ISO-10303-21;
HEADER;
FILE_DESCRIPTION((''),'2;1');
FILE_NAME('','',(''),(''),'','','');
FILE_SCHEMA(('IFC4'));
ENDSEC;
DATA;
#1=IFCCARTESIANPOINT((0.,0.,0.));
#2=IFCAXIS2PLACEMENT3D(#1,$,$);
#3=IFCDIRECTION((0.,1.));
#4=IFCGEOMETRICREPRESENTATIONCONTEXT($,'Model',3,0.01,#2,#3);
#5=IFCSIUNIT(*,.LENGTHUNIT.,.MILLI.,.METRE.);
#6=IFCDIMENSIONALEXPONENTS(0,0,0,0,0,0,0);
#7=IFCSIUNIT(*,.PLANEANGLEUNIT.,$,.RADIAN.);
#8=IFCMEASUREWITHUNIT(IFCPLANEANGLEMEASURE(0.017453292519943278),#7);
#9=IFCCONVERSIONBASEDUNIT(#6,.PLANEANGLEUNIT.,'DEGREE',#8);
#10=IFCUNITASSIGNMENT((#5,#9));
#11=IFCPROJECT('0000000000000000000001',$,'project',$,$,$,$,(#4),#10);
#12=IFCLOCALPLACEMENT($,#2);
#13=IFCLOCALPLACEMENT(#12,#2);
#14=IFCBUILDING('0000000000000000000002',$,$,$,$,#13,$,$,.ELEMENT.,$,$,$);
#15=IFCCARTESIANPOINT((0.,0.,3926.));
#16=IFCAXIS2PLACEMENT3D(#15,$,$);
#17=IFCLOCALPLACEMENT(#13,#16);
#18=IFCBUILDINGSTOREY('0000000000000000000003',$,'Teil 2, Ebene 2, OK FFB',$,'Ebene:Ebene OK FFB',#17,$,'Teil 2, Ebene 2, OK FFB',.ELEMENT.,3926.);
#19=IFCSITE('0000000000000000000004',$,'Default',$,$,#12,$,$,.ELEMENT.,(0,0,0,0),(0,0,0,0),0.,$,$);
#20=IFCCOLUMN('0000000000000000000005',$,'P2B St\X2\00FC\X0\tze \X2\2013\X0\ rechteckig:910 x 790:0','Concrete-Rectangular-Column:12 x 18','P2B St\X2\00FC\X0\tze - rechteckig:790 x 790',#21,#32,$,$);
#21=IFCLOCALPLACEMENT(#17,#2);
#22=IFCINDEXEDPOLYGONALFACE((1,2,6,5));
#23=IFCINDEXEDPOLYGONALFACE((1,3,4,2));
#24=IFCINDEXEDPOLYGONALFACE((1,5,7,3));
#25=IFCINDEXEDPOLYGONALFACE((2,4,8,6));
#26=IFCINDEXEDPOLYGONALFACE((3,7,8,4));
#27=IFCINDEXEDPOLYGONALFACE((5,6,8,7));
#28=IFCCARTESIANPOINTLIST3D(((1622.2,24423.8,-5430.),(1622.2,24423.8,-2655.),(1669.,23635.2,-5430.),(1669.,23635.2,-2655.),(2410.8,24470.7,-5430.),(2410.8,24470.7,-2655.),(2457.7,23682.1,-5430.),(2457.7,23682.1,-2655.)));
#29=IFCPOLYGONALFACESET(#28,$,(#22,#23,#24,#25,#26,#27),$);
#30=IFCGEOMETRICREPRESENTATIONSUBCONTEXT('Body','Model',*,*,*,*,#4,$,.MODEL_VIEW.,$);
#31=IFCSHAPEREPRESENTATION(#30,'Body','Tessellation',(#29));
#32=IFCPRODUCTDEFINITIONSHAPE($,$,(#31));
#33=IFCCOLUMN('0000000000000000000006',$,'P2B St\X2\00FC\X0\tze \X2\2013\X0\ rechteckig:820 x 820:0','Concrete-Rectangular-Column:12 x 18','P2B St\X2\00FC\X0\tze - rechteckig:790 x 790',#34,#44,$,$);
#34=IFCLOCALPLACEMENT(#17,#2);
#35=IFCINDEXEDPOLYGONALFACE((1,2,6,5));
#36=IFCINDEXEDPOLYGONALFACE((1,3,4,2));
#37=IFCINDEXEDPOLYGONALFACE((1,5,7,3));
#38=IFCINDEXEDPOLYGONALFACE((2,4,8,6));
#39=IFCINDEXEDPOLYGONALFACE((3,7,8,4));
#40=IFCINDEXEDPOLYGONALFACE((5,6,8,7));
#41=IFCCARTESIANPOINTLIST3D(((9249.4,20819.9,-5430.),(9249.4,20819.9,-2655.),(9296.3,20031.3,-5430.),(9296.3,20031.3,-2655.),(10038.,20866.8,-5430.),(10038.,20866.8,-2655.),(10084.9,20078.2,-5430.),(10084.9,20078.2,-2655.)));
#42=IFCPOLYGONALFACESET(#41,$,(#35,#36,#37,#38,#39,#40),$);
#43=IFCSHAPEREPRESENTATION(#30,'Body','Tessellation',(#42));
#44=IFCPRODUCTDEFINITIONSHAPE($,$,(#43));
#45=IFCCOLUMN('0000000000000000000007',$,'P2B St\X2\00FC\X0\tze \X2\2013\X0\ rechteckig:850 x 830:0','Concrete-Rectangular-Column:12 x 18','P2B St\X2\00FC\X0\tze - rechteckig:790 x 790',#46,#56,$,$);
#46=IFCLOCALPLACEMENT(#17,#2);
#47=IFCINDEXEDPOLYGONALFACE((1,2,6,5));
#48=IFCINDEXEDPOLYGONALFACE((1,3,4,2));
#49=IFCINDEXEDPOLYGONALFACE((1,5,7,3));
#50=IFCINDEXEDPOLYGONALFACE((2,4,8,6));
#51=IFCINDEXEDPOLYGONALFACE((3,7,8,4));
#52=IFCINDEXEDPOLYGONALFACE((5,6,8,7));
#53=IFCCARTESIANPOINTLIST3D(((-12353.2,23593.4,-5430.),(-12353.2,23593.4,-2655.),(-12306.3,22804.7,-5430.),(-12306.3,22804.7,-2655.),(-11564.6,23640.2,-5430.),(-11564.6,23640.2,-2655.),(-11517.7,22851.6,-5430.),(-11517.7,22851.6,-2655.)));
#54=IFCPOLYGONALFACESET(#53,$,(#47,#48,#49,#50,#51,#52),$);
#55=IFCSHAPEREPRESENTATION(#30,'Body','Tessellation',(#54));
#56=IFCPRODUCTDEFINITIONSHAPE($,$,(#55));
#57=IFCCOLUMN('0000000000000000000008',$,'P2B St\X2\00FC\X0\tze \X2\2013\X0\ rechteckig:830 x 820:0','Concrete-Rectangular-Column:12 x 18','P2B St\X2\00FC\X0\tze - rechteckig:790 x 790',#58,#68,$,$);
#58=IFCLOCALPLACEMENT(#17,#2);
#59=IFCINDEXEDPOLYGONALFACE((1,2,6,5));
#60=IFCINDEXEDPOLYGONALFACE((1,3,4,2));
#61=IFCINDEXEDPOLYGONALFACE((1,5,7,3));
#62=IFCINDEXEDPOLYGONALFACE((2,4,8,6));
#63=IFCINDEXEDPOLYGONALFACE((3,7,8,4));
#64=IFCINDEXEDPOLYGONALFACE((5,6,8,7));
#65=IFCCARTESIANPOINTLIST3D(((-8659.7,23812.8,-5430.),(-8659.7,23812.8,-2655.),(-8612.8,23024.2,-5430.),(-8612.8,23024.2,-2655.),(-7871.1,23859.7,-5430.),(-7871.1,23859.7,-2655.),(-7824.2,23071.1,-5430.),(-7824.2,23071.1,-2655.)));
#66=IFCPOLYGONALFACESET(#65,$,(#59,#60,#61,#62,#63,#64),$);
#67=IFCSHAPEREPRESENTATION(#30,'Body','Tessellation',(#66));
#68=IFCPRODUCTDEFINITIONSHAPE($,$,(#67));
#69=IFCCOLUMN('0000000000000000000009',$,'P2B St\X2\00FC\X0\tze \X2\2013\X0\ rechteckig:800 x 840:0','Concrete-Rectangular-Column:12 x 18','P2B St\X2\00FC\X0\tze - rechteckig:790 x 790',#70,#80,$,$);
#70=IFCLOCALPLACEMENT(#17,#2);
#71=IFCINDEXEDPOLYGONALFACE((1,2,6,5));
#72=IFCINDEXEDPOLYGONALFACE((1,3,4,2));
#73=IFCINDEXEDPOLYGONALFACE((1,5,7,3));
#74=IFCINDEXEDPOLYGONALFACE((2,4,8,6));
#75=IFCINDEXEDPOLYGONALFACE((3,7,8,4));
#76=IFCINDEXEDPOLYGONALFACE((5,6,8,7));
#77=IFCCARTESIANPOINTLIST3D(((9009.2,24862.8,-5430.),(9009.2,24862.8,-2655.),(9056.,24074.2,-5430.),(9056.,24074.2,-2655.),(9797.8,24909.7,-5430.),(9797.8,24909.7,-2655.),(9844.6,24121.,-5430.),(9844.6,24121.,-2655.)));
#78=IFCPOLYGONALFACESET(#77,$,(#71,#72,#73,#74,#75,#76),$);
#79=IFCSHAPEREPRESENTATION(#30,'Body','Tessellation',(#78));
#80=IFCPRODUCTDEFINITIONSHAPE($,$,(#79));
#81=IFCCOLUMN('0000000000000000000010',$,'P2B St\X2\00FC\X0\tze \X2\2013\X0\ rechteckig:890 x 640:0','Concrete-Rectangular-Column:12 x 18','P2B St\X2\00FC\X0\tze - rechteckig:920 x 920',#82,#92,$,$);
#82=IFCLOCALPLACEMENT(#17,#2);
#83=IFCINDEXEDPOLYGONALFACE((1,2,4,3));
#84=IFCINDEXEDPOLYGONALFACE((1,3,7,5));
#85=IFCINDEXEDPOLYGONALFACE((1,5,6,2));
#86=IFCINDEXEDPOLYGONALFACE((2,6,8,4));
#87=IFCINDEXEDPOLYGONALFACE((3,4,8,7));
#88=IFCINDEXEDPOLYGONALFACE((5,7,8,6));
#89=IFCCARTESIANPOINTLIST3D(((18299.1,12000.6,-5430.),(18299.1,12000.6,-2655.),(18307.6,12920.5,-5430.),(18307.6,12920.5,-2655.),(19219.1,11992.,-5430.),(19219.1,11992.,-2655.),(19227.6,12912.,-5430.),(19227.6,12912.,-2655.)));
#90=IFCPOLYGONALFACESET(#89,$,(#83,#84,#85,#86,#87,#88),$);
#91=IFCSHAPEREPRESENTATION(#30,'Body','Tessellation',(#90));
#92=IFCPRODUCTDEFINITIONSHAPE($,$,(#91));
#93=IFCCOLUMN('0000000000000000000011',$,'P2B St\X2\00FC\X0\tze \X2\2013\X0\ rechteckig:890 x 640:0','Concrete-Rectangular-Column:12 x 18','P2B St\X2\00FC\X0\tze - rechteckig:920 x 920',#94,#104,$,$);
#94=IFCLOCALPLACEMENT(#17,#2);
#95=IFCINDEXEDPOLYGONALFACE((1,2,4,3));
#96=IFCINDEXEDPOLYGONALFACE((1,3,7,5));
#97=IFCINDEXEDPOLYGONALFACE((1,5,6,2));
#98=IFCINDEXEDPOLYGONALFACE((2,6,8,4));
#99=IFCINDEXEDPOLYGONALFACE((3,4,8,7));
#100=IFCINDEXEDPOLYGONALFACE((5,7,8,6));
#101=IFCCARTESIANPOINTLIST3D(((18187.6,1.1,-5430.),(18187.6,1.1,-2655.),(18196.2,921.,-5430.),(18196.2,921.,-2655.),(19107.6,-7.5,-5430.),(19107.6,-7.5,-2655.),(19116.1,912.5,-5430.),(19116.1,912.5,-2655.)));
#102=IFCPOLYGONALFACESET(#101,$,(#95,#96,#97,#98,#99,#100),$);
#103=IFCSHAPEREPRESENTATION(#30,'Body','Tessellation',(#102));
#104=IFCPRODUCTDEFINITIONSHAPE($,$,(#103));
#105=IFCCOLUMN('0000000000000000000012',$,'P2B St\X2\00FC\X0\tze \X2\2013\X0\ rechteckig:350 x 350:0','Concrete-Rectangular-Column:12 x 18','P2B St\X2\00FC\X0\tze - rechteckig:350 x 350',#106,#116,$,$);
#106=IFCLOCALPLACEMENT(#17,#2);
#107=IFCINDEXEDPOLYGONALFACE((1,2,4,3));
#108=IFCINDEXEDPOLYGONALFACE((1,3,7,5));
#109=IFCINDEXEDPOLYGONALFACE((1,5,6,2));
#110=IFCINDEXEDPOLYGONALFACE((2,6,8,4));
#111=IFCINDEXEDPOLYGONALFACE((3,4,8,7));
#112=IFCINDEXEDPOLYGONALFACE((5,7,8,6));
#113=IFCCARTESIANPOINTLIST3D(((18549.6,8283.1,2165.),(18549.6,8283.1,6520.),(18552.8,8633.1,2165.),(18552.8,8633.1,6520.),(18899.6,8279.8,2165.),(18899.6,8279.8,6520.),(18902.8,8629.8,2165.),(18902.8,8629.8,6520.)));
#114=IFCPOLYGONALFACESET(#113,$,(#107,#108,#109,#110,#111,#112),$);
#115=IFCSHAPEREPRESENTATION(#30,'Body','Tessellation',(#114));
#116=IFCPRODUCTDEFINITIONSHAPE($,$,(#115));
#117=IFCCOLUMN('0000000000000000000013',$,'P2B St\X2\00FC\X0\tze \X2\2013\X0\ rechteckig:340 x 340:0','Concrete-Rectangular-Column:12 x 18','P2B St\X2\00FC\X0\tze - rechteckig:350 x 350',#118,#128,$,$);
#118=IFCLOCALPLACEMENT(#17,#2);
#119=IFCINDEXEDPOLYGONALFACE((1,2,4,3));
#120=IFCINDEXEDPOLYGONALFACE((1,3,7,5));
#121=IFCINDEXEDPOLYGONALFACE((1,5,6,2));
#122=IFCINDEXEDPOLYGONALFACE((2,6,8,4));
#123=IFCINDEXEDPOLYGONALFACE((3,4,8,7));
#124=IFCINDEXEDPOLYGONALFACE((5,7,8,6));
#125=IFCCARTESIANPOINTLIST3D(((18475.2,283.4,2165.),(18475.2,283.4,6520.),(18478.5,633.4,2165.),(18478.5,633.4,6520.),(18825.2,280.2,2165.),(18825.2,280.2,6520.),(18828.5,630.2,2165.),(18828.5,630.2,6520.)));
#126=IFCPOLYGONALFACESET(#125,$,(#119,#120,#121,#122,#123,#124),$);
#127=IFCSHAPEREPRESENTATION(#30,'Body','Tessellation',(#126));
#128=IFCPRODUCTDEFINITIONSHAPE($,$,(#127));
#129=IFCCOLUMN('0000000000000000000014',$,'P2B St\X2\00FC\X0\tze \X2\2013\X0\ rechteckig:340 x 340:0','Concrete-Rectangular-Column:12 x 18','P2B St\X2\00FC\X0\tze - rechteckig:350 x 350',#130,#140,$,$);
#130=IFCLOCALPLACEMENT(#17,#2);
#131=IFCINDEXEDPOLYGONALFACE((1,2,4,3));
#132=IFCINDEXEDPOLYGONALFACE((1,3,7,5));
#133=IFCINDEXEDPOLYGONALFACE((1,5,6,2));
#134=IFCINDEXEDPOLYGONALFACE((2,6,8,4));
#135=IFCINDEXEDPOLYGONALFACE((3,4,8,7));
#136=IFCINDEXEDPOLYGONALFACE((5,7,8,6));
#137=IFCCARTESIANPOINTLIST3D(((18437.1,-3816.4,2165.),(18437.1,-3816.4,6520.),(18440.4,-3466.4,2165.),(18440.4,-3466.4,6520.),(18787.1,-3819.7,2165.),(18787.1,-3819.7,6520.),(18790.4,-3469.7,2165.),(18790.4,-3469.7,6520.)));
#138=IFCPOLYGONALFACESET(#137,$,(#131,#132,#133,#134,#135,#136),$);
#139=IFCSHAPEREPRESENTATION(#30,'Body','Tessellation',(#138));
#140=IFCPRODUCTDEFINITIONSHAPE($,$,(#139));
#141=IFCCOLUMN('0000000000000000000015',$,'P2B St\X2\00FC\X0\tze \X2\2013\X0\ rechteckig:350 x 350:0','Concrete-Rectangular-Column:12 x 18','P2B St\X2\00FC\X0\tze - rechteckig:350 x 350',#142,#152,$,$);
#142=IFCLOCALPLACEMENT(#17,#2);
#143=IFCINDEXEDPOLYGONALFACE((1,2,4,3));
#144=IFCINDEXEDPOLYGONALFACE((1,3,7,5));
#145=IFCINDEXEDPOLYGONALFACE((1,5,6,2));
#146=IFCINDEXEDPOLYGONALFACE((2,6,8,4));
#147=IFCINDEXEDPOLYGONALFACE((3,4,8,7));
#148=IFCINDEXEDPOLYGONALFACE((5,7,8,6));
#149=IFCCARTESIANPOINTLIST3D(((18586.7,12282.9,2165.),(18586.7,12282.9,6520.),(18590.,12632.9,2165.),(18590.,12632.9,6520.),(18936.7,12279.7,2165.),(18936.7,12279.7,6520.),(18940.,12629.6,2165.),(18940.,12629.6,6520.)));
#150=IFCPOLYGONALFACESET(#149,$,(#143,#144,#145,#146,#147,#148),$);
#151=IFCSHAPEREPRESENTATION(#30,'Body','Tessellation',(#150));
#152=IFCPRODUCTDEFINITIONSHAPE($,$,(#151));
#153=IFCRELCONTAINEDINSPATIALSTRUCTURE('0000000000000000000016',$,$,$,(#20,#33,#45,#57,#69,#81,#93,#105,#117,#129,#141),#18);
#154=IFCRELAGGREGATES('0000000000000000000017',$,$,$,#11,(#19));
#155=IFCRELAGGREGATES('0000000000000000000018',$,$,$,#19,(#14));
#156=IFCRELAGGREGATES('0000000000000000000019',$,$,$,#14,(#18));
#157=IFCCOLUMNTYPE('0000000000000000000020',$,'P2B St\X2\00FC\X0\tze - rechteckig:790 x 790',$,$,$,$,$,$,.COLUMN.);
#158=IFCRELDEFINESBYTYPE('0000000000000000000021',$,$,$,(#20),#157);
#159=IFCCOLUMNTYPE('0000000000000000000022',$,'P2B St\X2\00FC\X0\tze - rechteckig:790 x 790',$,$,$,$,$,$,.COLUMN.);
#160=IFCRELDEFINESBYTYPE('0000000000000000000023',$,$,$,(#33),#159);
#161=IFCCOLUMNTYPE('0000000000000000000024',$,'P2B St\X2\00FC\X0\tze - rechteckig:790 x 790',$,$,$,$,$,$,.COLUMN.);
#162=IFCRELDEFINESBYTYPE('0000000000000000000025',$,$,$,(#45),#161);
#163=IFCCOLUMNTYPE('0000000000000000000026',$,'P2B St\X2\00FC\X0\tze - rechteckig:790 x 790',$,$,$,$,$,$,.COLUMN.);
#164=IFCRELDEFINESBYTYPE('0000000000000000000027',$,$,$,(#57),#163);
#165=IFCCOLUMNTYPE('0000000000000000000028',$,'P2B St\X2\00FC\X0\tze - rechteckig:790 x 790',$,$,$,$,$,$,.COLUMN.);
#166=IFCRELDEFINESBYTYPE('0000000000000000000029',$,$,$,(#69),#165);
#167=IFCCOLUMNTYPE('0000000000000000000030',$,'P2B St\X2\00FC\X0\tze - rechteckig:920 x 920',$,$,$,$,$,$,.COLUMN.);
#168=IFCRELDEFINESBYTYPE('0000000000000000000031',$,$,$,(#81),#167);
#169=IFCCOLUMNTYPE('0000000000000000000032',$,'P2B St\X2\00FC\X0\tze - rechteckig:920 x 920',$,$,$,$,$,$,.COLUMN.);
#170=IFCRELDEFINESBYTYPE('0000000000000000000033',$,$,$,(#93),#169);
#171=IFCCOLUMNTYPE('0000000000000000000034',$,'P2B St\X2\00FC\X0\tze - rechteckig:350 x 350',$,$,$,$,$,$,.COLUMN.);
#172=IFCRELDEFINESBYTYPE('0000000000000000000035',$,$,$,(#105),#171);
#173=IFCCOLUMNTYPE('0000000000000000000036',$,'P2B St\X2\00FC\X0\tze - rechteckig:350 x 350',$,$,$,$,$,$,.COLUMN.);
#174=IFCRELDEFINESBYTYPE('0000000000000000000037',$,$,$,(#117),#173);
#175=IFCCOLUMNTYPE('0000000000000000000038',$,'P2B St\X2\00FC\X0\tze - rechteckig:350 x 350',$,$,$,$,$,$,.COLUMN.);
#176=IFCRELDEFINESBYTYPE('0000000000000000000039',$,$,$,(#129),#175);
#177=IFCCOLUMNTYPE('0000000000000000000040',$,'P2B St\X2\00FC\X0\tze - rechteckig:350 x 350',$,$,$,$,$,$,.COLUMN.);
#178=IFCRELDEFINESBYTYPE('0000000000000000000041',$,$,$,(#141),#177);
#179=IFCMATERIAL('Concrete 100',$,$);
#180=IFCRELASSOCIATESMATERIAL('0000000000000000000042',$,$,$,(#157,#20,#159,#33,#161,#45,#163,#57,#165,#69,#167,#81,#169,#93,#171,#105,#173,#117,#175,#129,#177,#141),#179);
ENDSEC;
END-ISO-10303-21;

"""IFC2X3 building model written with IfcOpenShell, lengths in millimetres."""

from ifc_helpers import new_model, entity, si_unit, converted_unit, direction, frame, frame_2d, origin, origin_2d_with_axis, place, context, subcontext, project, spatial, rectangle, extrude, source, transform, mapped, material, type_object, type_shapes, element, save


model = new_model("IFC2X3")

# Units and contexts
model_context = context("Model", 3, precision=0.01, world=origin(), true_north=direction((0.0, 1.0)))
body_context = subcontext(model_context, "Body", "Model", "MODEL_VIEW")
ifc_project = project(units=[si_unit("LENGTHUNIT", "METRE", prefix="MILLI"), converted_unit("PLANEANGLEUNIT", "DEGREE", entity("IfcPlaneAngleMeasure", 0.017453292519943278), si_unit("PLANEANGLEUNIT", "RADIAN"), dimensions=[0, 0, 0, 0, 0, 0, 0])], contexts=[model_context])

# Site, building, storey
site_placement = place(None, origin())
site = spatial("IfcSite", under=ifc_project, at=site_placement, Name="Default", CompositionType="ELEMENT", RefLatitude=(0, 0, 0, 0), RefLongitude=(0, 0, 0, 0), RefElevation=0.0)
building_placement = place(site_placement, origin())
building = spatial("IfcBuilding", under=site, at=building_placement, CompositionType="ELEMENT")
storey_placement = place(building_placement, frame((0.0, 0.0, 3926.0)))
storey = spatial("IfcBuildingStorey", under=building, at=storey_placement, Name="Teil 2, Ebene 2, OK FFB", ObjectType="Ebene:Ebene OK FFB", LongName="Teil 2, Ebene 2, OK FFB", CompositionType="ELEMENT", Elevation=3926.0)

# Columns
ifc_material_1 = material(Name="Concrete 100")
column_type_1 = type_object("IfcColumnType", Name="P2B Stütze - rechteckig:790 x 790", PredefinedType="COLUMN", material=ifc_material_1)
shared_shape_1 = source(origin(), body_context, "Body", "SweptSolid", [
    extrude(rectangle(XDim=790.0, YDim=790.0, at=frame_2d((0.0, 0.0), x_axis=(1.0, 0.0))), frame((2039.9, 24053.0, -1504.0), z_axis=(0.0, 0.0, 1.0), x_axis=(-0.998239, -0.059319, 0.0)), (0.0, 0.0, 1.0), 2775.0),
])
type_shapes(column_type_1, [shared_shape_1])
column_1_placement = place(storey_placement, frame((0.0, 0.0, -3926.0)))
element("IfcColumn", 1, at=column_1_placement, inside=storey, type_object=column_type_1, material=ifc_material_1, Name="P2B Stütze – rechteckig:910 x 790:0", Description="Concrete-Rectangular-Column:12 x 18", ObjectType="P2B Stütze - rechteckig:790 x 790", context=body_context, shape_type="MappedRepresentation", body=[
    mapped(shared_shape_1, transform((0.0, 0.0, 0.0), scale=1.0)),
])
column_type_2 = type_object("IfcColumnType", Name="P2B Stütze - rechteckig:790 x 790", PredefinedType="COLUMN", material=ifc_material_1)
shared_shape_2 = source(origin(), body_context, "Body", "SweptSolid", [
    extrude(rectangle(XDim=790.0, YDim=790.0, at=frame_2d((0.0, 0.0), x_axis=(1.0, 0.0))), frame((9667.1, 20449.0, -1504.0), z_axis=(0.0, 0.0, 1.0), x_axis=(-0.998239, -0.059319, 0.0)), (0.0, 0.0, 1.0), 2775.0),
])
type_shapes(column_type_2, [shared_shape_2])
column_2_placement = place(storey_placement, frame((0.0, 0.0, -3926.0)))
element("IfcColumn", 2, at=column_2_placement, inside=storey, type_object=column_type_2, material=ifc_material_1, Name="P2B Stütze – rechteckig:820 x 820:0", Description="Concrete-Rectangular-Column:12 x 18", ObjectType="P2B Stütze - rechteckig:790 x 790", context=body_context, shape_type="MappedRepresentation", body=[
    mapped(shared_shape_2, transform((0.0, 0.0, 0.0), scale=1.0)),
])
column_type_3 = type_object("IfcColumnType", Name="P2B Stütze - rechteckig:790 x 790", PredefinedType="COLUMN", material=ifc_material_1)
shared_shape_3 = source(origin(), body_context, "Body", "SweptSolid", [
    extrude(rectangle(XDim=790.0, YDim=790.0, at=origin_2d_with_axis()), frame((-11935.4, 23222.5, -1504.0), z_axis=(0.0, 0.0, 1.0), x_axis=(-0.998239, -0.059319, 0.0)), (0.0, 0.0, 1.0), 2775.0),
])
type_shapes(column_type_3, [shared_shape_3])
column_3_placement = place(storey_placement, frame((0.0, 0.0, -3926.0)))
element("IfcColumn", 3, at=column_3_placement, inside=storey, type_object=column_type_3, material=ifc_material_1, Name="P2B Stütze – rechteckig:850 x 830:0", Description="Concrete-Rectangular-Column:12 x 18", ObjectType="P2B Stütze - rechteckig:790 x 790", context=body_context, shape_type="MappedRepresentation", body=[
    mapped(shared_shape_3, transform((0.0, 0.0, 0.0), scale=1.0)),
])
column_type_4 = type_object("IfcColumnType", Name="P2B Stütze - rechteckig:790 x 790", PredefinedType="COLUMN", material=ifc_material_1)
shared_shape_4 = source(origin(), body_context, "Body", "SweptSolid", [
    extrude(rectangle(XDim=790.0, YDim=790.0, at=frame_2d((0.0, 0.0), x_axis=(1.0, 0.0))), frame((-8241.9, 23442.0, -1504.0), z_axis=(0.0, 0.0, 1.0), x_axis=(-0.998239, -0.059319, 0.0)), (0.0, 0.0, 1.0), 2775.0),
])
type_shapes(column_type_4, [shared_shape_4])
column_4_placement = place(storey_placement, frame((0.0, 0.0, -3926.0)))
element("IfcColumn", 4, at=column_4_placement, inside=storey, type_object=column_type_4, material=ifc_material_1, Name="P2B Stütze – rechteckig:830 x 820:0", Description="Concrete-Rectangular-Column:12 x 18", ObjectType="P2B Stütze - rechteckig:790 x 790", context=body_context, shape_type="MappedRepresentation", body=[
    mapped(shared_shape_4, transform((0.0, 0.0, 0.0), scale=1.0)),
])
column_type_5 = type_object("IfcColumnType", Name="P2B Stütze - rechteckig:790 x 790", PredefinedType="COLUMN", material=ifc_material_1)
shared_shape_5 = source(origin(), body_context, "Body", "SweptSolid", [
    extrude(rectangle(XDim=790.0, YDim=790.0, at=frame_2d((0.0, 0.0), x_axis=(1.0, 0.0))), frame((9426.9, 24491.9, -1504.0), z_axis=(0.0, 0.0, 1.0), x_axis=(-0.998239, -0.059319, 0.0)), (0.0, 0.0, 1.0), 2775.0),
])
type_shapes(column_type_5, [shared_shape_5])
column_5_placement = place(storey_placement, frame((0.0, 0.0, -3926.0)))
element("IfcColumn", 5, at=column_5_placement, inside=storey, type_object=column_type_5, material=ifc_material_1, Name="P2B Stütze – rechteckig:800 x 840:0", Description="Concrete-Rectangular-Column:12 x 18", ObjectType="P2B Stütze - rechteckig:790 x 790", context=body_context, shape_type="MappedRepresentation", body=[
    mapped(shared_shape_5, transform((0.0, 0.0, 0.0), scale=1.0)),
])
column_type_6 = type_object("IfcColumnType", Name="P2B Stütze - rechteckig:920 x 920", PredefinedType="COLUMN", material=ifc_material_1)
shared_shape_6 = source(origin(), body_context, "Body", "SweptSolid", [
    extrude(rectangle(XDim=920.0, YDim=920.0, at=origin_2d_with_axis()), frame((18763.4, 12456.3, -1504.0), z_axis=(0.0, 0.0, 1.0), x_axis=(-0.999957, 0.00929, 0.0)), (0.0, 0.0, 1.0), 2775.0),
])
type_shapes(column_type_6, [shared_shape_6])
column_6_placement = place(storey_placement, frame((0.0, 0.0, -3926.0)))
element("IfcColumn", 6, at=column_6_placement, inside=storey, type_object=column_type_6, material=ifc_material_1, Name="P2B Stütze – rechteckig:890 x 640:0", Description="Concrete-Rectangular-Column:12 x 18", ObjectType="P2B Stütze - rechteckig:920 x 920", context=body_context, shape_type="MappedRepresentation", body=[
    mapped(shared_shape_6, transform((0.0, 0.0, 0.0), scale=1.0)),
])
column_type_7 = type_object("IfcColumnType", Name="P2B Stütze - rechteckig:920 x 920", PredefinedType="COLUMN", material=ifc_material_1)
shared_shape_7 = source(origin(), body_context, "Body", "SweptSolid", [
    extrude(rectangle(XDim=920.0, YDim=920.0, at=frame_2d((0.0, 0.0), x_axis=(1.0, 0.0))), frame((18651.9, 456.8, -1504.0), z_axis=(0.0, 0.0, 1.0), x_axis=(-0.999957, 0.009291, 0.0)), (0.0, 0.0, 1.0), 2775.0),
])
type_shapes(column_type_7, [shared_shape_7])
column_7_placement = place(storey_placement, frame((0.0, 0.0, -3926.0)))
element("IfcColumn", 7, at=column_7_placement, inside=storey, type_object=column_type_7, material=ifc_material_1, Name="P2B Stütze – rechteckig:890 x 640:0", Description="Concrete-Rectangular-Column:12 x 18", ObjectType="P2B Stütze - rechteckig:920 x 920", context=body_context, shape_type="MappedRepresentation", body=[
    mapped(shared_shape_7, transform((0.0, 0.0, 0.0), scale=1.0)),
])
column_type_8 = type_object("IfcColumnType", Name="P2B Stütze - rechteckig:350 x 350", PredefinedType="COLUMN", material=ifc_material_1)
shared_shape_8 = source(origin(), body_context, "Body", "SweptSolid", [
    extrude(rectangle(XDim=350.0, YDim=350.0, at=frame_2d((0.0, 0.0), x_axis=(1.0, 0.0))), frame((18726.2, 8456.4, 6091.0), z_axis=(0.0, 0.0, 1.0), x_axis=(-0.999957, 0.009291, 0.0)), (0.0, 0.0, 1.0), 4355.0),
])
type_shapes(column_type_8, [shared_shape_8])
column_8_placement = place(storey_placement, frame((0.0, 0.0, -3926.0)))
element("IfcColumn", 8, at=column_8_placement, inside=storey, type_object=column_type_8, material=ifc_material_1, Name="P2B Stütze – rechteckig:350 x 350:0", Description="Concrete-Rectangular-Column:12 x 18", ObjectType="P2B Stütze - rechteckig:350 x 350", context=body_context, shape_type="MappedRepresentation", body=[
    mapped(shared_shape_8, transform((0.0, 0.0, 0.0), scale=1.0)),
])
column_type_9 = type_object("IfcColumnType", Name="P2B Stütze - rechteckig:350 x 350", PredefinedType="COLUMN", material=ifc_material_1)
shared_shape_9 = source(origin(), body_context, "Body", "SweptSolid", [
    extrude(rectangle(XDim=350.0, YDim=350.0, at=frame_2d((0.0, 0.0), x_axis=(1.0, 0.0))), frame((18651.9, 456.8, 6091.0), z_axis=(0.0, 0.0, 1.0), x_axis=(-0.999957, 0.00929, 0.0)), (0.0, 0.0, 1.0), 4355.0),
])
type_shapes(column_type_9, [shared_shape_9])
column_9_placement = place(storey_placement, frame((0.0, 0.0, -3926.0)))
element("IfcColumn", 9, at=column_9_placement, inside=storey, type_object=column_type_9, material=ifc_material_1, Name="P2B Stütze – rechteckig:340 x 340:0", Description="Concrete-Rectangular-Column:12 x 18", ObjectType="P2B Stütze - rechteckig:350 x 350", context=body_context, shape_type="MappedRepresentation", body=[
    mapped(shared_shape_9, transform((0.0, 0.0, 0.0), scale=1.0)),
])
column_type_10 = type_object("IfcColumnType", Name="P2B Stütze - rechteckig:350 x 350", PredefinedType="COLUMN", material=ifc_material_1)
shared_shape_10 = source(origin(), body_context, "Body", "SweptSolid", [
    extrude(rectangle(XDim=350.0, YDim=350.0, at=frame_2d((0.0, 0.0), x_axis=(1.0, 0.0))), frame((18613.8, -3643.0, 6091.0), z_axis=(0.0, 0.0, 1.0), x_axis=(-0.999957, 0.009291, 0.0)), (0.0, 0.0, 1.0), 4355.0),
])
type_shapes(column_type_10, [shared_shape_10])
column_10_placement = place(storey_placement, frame((0.0, 0.0, -3926.0)))
element("IfcColumn", 10, at=column_10_placement, inside=storey, type_object=column_type_10, material=ifc_material_1, Name="P2B Stütze – rechteckig:340 x 340:0", Description="Concrete-Rectangular-Column:12 x 18", ObjectType="P2B Stütze - rechteckig:350 x 350", context=body_context, shape_type="MappedRepresentation", body=[
    mapped(shared_shape_10, transform((0.0, 0.0, 0.0), scale=1.0)),
])
column_type_11 = type_object("IfcColumnType", Name="P2B Stütze - rechteckig:350 x 350", PredefinedType="COLUMN", material=ifc_material_1)
shared_shape_11 = source(origin(), body_context, "Body", "SweptSolid", [
    extrude(rectangle(XDim=350.0, YDim=350.0, at=frame_2d((0.0, 0.0), x_axis=(1.0, 0.0))), frame((18763.4, 12456.3, 6091.0), z_axis=(0.0, 0.0, 1.0), x_axis=(-0.999957, 0.009291, 0.0)), (0.0, 0.0, 1.0), 4355.0),
])
type_shapes(column_type_11, [shared_shape_11])
column_11_placement = place(storey_placement, frame((0.0, 0.0, -3926.0)))
element("IfcColumn", 11, at=column_11_placement, inside=storey, type_object=column_type_11, material=ifc_material_1, Name="P2B Stütze – rechteckig:350 x 350:0", Description="Concrete-Rectangular-Column:12 x 18", ObjectType="P2B Stütze - rechteckig:350 x 350", context=body_context, shape_type="MappedRepresentation", body=[
    mapped(shared_shape_11, transform((0.0, 0.0, 0.0), scale=1.0)),
])

save(model, "model.ifc")
